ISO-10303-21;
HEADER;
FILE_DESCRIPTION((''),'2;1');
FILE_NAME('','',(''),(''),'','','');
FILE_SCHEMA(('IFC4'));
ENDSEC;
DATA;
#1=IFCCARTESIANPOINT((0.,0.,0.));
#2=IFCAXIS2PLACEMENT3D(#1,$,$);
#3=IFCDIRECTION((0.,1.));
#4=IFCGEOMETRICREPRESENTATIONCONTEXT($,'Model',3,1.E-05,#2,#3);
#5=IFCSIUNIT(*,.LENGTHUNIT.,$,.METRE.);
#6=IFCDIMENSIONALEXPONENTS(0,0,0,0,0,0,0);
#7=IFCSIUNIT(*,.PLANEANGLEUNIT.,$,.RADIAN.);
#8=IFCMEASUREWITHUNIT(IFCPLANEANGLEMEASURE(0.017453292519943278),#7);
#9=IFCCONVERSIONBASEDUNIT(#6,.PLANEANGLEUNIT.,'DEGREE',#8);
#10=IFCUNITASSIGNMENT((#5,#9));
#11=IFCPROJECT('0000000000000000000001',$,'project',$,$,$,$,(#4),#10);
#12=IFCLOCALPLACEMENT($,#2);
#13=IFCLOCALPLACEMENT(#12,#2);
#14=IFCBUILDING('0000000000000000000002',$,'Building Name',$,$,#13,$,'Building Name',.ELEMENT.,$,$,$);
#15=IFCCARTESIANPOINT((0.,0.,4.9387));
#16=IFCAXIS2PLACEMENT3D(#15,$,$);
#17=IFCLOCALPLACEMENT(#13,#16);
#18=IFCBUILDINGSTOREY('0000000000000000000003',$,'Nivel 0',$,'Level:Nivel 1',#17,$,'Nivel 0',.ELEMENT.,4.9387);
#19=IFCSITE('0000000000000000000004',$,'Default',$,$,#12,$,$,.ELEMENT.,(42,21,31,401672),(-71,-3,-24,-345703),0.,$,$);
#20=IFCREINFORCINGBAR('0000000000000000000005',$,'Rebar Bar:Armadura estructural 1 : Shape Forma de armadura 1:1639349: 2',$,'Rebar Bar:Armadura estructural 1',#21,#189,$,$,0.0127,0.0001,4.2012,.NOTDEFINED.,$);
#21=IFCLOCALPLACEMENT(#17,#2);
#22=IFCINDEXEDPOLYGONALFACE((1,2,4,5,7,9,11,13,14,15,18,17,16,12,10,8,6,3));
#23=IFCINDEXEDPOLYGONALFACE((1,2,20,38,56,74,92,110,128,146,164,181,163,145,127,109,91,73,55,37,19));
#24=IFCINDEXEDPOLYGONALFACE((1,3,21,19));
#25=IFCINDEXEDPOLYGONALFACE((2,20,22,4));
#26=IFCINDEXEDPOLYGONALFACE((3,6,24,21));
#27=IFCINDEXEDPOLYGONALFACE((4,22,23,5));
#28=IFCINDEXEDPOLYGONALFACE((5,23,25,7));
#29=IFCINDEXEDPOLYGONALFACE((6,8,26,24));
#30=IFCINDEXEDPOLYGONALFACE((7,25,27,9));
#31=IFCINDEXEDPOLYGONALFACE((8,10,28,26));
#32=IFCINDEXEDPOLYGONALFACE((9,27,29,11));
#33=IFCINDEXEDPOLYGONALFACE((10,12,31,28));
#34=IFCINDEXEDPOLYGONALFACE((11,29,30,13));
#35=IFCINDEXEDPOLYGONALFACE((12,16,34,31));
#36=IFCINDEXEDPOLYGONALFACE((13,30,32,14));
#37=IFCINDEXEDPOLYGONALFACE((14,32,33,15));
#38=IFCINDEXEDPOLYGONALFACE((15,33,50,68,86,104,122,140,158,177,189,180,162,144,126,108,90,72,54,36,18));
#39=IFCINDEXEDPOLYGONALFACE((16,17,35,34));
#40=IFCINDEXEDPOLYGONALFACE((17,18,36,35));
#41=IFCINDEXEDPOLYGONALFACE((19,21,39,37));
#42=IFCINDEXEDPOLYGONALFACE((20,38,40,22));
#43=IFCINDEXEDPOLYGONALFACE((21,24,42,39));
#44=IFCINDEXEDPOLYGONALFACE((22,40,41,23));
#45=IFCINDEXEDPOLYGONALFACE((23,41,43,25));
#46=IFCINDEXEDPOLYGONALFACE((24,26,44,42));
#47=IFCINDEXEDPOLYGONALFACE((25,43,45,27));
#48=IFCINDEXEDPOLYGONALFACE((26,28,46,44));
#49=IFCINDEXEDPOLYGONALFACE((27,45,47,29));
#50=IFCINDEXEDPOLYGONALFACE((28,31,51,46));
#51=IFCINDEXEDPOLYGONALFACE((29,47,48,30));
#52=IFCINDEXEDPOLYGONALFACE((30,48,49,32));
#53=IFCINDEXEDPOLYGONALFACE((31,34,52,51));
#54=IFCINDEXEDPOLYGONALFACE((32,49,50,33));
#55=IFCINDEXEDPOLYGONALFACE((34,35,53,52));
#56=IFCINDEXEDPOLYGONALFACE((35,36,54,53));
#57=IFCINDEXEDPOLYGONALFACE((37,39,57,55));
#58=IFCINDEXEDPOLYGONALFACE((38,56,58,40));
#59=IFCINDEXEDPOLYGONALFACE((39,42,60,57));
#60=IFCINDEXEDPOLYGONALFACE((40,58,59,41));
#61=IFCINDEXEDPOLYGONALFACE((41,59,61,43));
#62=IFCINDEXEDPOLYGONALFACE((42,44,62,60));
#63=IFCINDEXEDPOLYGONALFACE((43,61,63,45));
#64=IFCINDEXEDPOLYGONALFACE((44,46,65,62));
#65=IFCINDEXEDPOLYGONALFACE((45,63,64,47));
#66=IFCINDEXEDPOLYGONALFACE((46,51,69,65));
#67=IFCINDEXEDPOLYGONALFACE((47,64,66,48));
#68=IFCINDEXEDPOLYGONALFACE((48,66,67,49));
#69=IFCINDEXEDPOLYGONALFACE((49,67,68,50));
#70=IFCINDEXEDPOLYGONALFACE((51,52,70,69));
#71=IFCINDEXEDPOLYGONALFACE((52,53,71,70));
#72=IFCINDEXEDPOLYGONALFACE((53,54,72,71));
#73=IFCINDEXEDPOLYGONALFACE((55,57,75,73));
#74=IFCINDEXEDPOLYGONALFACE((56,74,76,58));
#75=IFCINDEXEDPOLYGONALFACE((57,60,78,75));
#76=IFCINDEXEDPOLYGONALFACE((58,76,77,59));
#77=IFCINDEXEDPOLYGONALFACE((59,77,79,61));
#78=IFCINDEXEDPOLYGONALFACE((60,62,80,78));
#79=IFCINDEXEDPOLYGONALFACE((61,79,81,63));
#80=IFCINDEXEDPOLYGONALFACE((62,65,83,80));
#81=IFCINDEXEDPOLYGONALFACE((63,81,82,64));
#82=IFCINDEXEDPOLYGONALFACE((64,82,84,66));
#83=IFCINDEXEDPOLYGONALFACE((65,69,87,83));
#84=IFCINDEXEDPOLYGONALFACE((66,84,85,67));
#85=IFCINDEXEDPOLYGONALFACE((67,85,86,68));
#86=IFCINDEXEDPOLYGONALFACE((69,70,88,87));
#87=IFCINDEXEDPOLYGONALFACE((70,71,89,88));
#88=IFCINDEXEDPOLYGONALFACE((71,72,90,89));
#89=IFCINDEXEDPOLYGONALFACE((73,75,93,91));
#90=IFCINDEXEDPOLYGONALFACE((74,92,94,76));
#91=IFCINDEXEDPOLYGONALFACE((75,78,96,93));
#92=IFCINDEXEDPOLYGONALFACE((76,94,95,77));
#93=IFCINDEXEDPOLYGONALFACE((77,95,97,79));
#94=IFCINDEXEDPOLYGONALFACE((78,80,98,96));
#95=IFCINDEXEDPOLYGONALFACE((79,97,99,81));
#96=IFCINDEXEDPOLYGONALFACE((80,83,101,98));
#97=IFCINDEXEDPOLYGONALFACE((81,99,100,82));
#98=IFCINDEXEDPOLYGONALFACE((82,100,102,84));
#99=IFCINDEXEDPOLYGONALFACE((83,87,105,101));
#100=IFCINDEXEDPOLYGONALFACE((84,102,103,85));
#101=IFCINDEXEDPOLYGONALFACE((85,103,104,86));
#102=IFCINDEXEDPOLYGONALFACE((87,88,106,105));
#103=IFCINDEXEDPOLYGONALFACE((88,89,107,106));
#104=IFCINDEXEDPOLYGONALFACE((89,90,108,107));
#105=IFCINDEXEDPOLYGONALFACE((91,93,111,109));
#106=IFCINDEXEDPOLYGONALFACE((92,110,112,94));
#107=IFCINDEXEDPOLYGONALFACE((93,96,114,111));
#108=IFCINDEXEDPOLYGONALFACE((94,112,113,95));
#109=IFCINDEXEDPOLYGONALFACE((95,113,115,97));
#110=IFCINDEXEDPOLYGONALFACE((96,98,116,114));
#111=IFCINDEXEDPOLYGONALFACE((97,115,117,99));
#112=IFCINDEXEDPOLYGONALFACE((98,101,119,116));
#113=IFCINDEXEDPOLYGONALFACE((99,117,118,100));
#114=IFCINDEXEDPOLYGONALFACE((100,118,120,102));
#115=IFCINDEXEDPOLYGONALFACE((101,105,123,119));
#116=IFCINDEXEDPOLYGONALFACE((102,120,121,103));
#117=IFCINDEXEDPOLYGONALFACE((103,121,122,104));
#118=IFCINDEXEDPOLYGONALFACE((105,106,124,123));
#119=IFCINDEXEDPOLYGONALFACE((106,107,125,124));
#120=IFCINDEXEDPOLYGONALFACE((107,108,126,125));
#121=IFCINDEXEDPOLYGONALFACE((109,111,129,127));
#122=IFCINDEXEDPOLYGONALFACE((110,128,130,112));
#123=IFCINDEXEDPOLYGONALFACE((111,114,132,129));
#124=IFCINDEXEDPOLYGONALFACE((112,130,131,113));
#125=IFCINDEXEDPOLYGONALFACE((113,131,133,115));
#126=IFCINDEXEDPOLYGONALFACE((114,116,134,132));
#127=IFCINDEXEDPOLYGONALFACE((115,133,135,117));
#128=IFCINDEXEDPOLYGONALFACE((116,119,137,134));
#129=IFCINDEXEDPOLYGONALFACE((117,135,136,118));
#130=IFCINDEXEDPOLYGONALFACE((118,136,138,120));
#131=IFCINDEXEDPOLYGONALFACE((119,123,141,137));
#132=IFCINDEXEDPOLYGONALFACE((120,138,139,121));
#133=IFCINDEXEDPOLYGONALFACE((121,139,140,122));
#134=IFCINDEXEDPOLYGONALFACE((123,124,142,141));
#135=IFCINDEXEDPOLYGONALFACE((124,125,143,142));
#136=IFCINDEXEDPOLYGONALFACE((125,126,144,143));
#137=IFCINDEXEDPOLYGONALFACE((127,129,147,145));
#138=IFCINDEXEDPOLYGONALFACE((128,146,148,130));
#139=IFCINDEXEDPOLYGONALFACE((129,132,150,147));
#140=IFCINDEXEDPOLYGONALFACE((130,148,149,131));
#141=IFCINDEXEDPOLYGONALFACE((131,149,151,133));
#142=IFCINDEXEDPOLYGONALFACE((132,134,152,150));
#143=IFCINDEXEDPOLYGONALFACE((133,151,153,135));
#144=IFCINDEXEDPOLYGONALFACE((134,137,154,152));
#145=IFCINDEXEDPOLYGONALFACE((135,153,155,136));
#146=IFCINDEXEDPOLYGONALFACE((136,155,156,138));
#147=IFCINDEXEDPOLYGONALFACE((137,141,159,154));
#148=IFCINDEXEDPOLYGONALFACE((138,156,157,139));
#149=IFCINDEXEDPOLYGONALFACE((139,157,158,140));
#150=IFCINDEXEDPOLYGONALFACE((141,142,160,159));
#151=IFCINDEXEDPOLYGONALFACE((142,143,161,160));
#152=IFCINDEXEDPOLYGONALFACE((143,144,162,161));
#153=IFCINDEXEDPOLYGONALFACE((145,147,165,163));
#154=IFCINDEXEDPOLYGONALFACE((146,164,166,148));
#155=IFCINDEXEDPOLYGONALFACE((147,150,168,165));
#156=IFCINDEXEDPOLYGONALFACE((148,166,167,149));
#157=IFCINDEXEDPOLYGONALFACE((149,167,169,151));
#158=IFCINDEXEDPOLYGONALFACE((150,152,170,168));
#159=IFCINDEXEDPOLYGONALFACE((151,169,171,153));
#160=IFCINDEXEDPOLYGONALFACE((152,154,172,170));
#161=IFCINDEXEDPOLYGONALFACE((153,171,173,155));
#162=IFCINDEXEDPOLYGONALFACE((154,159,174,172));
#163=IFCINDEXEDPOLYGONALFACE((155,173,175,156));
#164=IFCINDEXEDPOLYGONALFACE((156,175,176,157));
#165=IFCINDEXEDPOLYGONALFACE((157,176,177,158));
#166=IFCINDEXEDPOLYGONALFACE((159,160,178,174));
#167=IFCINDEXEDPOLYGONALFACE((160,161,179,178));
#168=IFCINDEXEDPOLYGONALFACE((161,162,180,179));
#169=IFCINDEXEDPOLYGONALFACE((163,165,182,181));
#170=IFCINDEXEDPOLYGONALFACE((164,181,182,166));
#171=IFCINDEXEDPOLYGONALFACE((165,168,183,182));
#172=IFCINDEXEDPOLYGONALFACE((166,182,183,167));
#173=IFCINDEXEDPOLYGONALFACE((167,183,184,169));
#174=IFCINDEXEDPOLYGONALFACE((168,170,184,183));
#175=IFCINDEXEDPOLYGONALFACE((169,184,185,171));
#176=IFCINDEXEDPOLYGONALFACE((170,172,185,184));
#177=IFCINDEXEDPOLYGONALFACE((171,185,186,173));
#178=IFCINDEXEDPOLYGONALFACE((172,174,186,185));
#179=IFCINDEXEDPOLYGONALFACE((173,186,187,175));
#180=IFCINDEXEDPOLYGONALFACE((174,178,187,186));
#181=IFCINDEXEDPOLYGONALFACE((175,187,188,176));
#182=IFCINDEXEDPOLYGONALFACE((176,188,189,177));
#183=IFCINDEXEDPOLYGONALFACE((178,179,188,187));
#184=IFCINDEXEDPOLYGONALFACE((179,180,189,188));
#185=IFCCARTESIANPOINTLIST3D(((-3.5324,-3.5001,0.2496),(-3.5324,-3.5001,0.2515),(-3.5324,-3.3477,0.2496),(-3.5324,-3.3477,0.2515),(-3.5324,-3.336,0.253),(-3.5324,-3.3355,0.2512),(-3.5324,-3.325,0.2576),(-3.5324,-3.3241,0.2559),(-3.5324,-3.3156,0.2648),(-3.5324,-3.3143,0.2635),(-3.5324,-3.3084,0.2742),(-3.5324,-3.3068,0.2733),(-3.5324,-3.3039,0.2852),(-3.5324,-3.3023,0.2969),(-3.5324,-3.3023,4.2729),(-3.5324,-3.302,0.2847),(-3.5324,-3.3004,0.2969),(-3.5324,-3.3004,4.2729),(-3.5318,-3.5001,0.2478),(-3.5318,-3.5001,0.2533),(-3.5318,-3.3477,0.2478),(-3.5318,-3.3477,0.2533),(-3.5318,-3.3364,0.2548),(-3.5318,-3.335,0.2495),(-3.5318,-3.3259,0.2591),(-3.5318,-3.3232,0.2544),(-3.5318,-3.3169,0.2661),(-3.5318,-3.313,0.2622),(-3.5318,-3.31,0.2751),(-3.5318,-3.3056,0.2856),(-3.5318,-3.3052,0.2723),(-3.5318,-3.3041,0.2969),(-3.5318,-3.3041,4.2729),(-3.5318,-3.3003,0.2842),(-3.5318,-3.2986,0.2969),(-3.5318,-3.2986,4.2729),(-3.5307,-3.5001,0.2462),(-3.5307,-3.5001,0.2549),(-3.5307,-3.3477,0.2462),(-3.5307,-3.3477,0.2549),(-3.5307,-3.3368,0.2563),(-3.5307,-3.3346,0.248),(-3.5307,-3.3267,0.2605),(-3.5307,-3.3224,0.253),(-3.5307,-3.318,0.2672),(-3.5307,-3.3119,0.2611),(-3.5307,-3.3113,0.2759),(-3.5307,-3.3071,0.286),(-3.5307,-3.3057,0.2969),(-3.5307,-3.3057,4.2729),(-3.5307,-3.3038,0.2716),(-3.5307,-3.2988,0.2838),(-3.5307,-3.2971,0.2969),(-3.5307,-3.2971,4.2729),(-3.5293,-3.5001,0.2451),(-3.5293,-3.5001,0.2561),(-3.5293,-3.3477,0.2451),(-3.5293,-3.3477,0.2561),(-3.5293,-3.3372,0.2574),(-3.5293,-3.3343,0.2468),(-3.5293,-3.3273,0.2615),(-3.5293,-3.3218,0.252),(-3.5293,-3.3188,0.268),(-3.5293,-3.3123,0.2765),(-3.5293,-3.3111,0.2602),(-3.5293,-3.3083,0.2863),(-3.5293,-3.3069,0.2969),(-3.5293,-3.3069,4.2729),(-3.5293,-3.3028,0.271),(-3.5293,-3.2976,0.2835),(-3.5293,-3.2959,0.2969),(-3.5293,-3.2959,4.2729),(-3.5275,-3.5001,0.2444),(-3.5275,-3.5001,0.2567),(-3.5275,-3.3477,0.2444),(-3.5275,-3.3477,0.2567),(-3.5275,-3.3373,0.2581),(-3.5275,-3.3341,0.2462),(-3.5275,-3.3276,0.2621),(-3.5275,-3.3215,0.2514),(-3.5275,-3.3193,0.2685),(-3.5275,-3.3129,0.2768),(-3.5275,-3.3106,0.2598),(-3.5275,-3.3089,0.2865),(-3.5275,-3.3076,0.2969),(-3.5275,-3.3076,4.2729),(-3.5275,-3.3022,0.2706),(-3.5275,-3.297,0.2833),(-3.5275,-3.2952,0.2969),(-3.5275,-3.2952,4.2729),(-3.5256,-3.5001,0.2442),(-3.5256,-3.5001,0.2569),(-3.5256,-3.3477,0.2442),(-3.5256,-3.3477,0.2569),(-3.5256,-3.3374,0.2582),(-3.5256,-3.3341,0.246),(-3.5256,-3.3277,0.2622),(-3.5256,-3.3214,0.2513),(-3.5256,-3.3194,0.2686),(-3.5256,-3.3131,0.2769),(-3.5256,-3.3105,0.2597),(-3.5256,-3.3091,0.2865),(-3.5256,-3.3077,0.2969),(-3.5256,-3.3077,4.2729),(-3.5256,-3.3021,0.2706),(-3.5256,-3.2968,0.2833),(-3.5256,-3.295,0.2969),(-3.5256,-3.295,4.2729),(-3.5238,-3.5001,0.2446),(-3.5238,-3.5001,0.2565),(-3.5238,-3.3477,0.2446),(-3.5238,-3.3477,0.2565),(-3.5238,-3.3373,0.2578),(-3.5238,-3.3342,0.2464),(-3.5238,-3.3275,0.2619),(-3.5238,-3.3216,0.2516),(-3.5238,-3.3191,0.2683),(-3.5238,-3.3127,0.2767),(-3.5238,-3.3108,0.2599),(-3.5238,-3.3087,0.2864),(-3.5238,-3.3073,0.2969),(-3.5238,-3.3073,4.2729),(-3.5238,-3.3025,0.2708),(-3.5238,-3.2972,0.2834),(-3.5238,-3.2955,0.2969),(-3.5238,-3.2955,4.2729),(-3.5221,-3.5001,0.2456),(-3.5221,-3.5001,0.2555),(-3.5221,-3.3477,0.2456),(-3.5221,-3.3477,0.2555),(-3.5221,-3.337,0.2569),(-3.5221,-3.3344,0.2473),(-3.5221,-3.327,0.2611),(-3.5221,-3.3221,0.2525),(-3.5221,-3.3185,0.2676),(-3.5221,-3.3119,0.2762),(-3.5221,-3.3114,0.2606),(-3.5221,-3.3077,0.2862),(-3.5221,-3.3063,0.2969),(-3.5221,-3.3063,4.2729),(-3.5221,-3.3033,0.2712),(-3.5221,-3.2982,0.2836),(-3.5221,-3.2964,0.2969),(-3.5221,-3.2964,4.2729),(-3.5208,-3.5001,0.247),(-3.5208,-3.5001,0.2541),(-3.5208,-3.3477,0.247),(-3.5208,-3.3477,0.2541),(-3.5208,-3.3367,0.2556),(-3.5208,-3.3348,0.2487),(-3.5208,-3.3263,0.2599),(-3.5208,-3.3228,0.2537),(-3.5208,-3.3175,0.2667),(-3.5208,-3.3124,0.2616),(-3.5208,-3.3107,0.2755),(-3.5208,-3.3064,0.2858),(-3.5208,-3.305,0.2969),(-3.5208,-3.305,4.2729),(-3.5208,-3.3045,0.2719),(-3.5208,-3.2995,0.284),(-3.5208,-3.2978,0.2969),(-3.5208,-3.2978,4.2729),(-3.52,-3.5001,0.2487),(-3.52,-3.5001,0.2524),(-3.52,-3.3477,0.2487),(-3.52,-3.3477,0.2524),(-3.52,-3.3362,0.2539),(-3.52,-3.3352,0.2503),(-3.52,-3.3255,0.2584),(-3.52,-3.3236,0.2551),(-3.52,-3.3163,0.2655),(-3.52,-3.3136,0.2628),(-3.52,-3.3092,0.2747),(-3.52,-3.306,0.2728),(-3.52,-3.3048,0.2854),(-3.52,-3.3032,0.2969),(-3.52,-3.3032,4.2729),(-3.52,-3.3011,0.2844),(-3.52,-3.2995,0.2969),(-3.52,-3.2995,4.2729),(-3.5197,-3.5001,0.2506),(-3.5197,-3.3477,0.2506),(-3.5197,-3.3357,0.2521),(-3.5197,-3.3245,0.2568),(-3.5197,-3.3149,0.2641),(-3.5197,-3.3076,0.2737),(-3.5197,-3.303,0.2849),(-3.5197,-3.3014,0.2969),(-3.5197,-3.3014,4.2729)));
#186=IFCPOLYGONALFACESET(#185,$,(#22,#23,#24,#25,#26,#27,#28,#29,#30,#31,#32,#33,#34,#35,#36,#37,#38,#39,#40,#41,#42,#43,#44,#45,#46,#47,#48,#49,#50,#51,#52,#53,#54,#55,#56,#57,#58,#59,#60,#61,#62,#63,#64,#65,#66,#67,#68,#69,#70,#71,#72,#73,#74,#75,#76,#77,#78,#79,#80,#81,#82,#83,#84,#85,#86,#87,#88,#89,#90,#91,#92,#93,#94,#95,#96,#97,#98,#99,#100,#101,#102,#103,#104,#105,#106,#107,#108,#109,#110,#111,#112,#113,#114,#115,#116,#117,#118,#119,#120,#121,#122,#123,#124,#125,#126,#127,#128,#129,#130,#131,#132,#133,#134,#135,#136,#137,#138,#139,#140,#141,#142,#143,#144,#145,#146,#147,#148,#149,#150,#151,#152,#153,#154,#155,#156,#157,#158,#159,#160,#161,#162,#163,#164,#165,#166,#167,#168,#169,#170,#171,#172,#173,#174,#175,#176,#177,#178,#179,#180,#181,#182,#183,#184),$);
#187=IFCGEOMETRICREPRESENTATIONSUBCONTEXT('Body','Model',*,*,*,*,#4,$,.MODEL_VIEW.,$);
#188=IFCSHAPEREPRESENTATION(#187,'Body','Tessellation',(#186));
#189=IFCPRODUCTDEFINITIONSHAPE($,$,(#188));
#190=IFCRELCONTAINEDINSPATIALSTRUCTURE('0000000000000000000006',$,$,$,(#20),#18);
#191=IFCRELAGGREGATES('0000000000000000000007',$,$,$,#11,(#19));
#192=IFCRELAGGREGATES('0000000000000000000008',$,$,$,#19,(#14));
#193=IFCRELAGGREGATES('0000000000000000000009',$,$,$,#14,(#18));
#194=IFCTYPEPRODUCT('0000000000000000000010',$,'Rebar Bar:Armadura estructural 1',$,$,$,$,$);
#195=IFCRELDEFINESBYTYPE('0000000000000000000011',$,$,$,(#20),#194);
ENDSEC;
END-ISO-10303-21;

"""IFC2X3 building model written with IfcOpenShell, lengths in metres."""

from ifc_helpers import new_model, entity, si_unit, converted_unit, direction, frame, origin, place, context, subcontext, project, spatial, type_object, element, save


model = new_model("IFC2X3")

# Units and contexts
model_context = context("Model", 3, precision=1e-05, world=origin(), true_north=direction((0.0, 1.0)))
body_context = subcontext(model_context, "Body", "Model", "MODEL_VIEW")
ifc_project = project(units=[si_unit("LENGTHUNIT", "METRE"), converted_unit("PLANEANGLEUNIT", "DEGREE", entity("IfcPlaneAngleMeasure", 0.017453292519943278), si_unit("PLANEANGLEUNIT", "RADIAN"), dimensions=[0, 0, 0, 0, 0, 0, 0])], contexts=[model_context])

# Site, building, storey
site_placement = place(None, origin())
site = spatial("IfcSite", under=ifc_project, at=site_placement, Name="Default", CompositionType="ELEMENT", RefLatitude=(42, 21, 31, 401672), RefLongitude=(-71, -3, -24, -345703), RefElevation=0.0)
building_placement = place(site_placement, origin())
building = spatial("IfcBuilding", under=site, at=building_placement, Name="Building Name", LongName="Building Name", CompositionType="ELEMENT")
storey_placement = place(building_placement, frame((0.0, 0.0, 4.9387)))
storey = spatial("IfcBuildingStorey", under=building, at=storey_placement, Name="Nivel 0", ObjectType="Level:Nivel 1", LongName="Nivel 0", CompositionType="ELEMENT", Elevation=4.9387)

# Reinforcing bar
type_product = type_object("IfcTypeProduct", Name="Rebar Bar:Armadura estructural 1")
reinforcing_bar_1_placement = place(storey_placement, origin())
element("IfcReinforcingBar", 1, at=reinforcing_bar_1_placement, inside=storey, type_object=type_product, Name="Rebar Bar:Armadura estructural 1 : Shape Forma de armadura 1:1639349: 2", ObjectType="Rebar Bar:Armadura estructural 1", BarLength=4.2012, BarRole="NOTDEFINED", CrossSectionArea=0.0001, NominalDiameter=0.0127, context=body_context, shape_type="AdvancedSweptSolid", body=[
    entity("IfcSweptDiskSolid", entity("IfcCompositeCurve", [entity("IfcCompositeCurveSegment", "CONTINUOUS", True, entity("IfcPolyline", [entity("IfcCartesianPoint", [-3.5261, -3.5001, 0.2506]), entity("IfcCartesianPoint", [-3.5261, -3.3477, 0.2506])])), entity("IfcCompositeCurveSegment", "CONTINUOUS", True, entity("IfcTrimmedCurve", entity("IfcCircle", entity("IfcAxis2Placement3D", entity("IfcCartesianPoint", [-3.5261, -3.3477, 0.2969]), entity("IfcDirection", [1.0, 0.0, 0.0]), entity("IfcDirection", [0.0, 1.0, 0.0])), 0.0464), [entity("IfcParameterValue", 270.0)], [entity("IfcParameterValue", 360.0)], True, "PARAMETER")), entity("IfcCompositeCurveSegment", "CONTINUOUS", True, entity("IfcPolyline", [entity("IfcCartesianPoint", [-3.5261, -3.3014, 0.2969]), entity("IfcCartesianPoint", [-3.5261, -3.3014, 4.2729])]))], False), 0.0063, None, 0.0, 92.0),
])

save(model, "model.ifc")
